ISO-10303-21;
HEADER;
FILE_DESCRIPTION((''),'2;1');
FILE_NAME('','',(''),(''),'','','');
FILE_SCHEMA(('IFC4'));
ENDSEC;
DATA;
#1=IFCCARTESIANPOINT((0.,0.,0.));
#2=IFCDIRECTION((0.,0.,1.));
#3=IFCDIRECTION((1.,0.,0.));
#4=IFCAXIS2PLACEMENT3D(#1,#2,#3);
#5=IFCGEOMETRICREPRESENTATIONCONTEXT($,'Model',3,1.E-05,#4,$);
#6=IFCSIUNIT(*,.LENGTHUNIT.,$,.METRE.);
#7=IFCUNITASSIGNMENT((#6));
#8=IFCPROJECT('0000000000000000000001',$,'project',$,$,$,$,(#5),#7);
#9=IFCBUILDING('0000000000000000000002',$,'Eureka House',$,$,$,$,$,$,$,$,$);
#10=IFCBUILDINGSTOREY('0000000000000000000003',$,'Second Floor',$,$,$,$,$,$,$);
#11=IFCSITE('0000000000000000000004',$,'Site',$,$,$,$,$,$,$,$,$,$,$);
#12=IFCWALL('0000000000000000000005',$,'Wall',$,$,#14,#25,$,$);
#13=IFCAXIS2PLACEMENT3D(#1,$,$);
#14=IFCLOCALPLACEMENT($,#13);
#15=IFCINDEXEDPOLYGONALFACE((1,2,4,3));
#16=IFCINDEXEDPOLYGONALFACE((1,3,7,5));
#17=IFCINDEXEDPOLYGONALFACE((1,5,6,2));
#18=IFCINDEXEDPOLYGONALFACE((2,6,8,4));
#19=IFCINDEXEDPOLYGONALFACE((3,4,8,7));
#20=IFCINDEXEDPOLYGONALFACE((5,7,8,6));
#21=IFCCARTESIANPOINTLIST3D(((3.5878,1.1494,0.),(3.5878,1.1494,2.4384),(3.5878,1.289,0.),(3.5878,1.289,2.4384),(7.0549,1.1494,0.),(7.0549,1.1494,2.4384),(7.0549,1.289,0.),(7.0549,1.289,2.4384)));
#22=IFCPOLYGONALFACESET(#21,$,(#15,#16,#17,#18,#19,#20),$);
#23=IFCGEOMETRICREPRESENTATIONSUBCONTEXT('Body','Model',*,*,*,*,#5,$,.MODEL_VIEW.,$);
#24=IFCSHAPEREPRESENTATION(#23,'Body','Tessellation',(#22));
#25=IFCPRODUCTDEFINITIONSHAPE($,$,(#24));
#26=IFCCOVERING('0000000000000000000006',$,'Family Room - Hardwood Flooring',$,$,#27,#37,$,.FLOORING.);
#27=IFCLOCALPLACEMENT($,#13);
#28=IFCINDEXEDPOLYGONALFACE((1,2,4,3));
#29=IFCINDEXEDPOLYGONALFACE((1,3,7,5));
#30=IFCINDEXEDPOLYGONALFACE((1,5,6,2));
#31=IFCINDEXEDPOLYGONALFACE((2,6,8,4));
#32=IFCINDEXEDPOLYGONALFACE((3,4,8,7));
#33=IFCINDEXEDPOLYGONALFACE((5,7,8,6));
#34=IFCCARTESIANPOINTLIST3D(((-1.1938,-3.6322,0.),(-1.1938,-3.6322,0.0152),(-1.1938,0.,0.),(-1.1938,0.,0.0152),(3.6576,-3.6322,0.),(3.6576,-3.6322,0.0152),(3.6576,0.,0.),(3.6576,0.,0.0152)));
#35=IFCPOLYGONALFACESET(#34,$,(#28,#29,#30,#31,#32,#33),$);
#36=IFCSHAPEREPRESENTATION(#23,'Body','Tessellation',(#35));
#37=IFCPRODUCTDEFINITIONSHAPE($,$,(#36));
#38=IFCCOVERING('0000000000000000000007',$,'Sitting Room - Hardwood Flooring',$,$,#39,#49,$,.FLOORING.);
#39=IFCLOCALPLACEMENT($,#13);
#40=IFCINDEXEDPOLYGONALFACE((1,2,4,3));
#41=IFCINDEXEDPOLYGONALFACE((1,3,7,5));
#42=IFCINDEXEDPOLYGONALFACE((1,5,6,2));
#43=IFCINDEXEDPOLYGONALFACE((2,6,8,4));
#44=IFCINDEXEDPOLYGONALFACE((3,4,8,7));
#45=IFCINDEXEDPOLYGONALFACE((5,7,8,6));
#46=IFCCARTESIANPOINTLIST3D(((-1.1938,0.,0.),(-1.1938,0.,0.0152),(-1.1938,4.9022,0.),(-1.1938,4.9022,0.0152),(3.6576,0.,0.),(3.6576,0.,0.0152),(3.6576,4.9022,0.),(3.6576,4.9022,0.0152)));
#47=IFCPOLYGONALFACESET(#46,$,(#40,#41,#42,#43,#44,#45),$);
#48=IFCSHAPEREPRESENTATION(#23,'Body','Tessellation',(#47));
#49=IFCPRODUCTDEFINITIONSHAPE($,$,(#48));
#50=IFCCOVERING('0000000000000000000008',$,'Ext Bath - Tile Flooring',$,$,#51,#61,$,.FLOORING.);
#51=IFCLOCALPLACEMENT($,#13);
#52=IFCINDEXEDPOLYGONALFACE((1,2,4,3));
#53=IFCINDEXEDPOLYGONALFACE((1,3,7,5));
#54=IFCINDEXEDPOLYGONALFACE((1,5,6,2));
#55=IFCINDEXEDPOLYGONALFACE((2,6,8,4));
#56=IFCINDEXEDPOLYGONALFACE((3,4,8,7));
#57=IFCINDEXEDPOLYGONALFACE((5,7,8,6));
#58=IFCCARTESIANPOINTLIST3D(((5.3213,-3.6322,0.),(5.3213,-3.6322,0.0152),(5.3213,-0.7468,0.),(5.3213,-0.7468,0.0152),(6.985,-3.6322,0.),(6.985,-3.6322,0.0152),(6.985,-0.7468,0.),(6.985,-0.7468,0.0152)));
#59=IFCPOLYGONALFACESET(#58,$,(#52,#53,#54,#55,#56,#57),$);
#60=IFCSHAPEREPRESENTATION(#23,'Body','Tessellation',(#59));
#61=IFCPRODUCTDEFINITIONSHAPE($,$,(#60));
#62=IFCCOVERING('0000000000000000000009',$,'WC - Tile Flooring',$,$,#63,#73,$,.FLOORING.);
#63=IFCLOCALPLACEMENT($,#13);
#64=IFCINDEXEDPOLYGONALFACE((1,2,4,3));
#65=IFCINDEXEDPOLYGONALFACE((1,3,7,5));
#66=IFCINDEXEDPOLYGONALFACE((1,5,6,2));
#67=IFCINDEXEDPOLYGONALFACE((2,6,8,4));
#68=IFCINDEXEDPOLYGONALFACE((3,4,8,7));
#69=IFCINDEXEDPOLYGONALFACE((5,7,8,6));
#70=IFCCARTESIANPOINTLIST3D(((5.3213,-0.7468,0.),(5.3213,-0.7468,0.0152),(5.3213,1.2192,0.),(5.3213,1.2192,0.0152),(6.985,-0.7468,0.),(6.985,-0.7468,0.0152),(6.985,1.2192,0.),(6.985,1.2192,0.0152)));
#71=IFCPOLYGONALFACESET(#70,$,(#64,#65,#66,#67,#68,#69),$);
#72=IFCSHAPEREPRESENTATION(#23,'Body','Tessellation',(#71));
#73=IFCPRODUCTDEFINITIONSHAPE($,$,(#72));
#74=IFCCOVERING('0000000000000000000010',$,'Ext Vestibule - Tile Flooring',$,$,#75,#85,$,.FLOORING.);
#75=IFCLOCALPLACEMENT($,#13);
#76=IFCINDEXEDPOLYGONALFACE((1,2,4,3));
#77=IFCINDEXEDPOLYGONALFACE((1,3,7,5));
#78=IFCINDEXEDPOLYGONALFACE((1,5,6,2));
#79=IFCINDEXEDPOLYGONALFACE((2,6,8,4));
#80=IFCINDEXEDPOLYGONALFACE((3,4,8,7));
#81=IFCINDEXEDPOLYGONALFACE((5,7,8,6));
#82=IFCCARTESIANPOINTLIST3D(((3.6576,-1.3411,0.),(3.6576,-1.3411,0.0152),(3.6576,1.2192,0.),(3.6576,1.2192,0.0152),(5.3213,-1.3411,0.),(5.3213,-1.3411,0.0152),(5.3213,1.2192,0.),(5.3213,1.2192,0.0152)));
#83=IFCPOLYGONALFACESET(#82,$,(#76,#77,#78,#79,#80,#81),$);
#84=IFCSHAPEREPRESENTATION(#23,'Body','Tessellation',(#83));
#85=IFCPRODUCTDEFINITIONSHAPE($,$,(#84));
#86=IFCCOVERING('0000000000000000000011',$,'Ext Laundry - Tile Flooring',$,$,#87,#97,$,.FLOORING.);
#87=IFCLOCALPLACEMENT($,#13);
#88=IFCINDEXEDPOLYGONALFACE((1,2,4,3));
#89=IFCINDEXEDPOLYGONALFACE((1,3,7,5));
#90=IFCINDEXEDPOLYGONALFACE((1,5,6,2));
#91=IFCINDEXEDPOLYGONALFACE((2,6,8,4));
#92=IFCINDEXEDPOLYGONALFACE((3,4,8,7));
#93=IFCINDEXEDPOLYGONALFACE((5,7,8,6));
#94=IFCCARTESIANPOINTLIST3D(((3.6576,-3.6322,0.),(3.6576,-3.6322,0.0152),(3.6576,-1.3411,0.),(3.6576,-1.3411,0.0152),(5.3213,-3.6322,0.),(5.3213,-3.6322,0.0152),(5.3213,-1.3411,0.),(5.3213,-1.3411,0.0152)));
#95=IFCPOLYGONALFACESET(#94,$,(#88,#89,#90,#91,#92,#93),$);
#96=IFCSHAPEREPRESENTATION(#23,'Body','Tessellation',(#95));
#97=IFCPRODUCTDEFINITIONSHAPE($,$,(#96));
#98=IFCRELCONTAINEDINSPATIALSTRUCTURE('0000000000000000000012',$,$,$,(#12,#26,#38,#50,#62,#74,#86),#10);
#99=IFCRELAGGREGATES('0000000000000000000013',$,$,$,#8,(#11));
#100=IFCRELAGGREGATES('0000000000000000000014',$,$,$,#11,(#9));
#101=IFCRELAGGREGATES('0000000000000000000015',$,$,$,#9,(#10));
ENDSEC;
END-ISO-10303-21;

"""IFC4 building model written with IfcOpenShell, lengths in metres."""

from ifc_helpers import new_model, si_unit, frame, origin, origin_with_axes, origin_2d, place, context, subcontext, project, spatial, rectangle, extrude, element, save


model = new_model("IFC4")

# Units and contexts
model_context = context("Model", 3, precision=1e-05, world=origin_with_axes())
body_context = subcontext(model_context, "Body", "Model", "MODEL_VIEW")
ifc_project = project(units=[si_unit("LENGTHUNIT", "METRE")], contexts=[model_context])

# Site, building, storey
site = spatial("IfcSite", under=ifc_project, Name="Site")
building = spatial("IfcBuilding", under=site, Name="Eureka House")
storey = spatial("IfcBuildingStorey", under=building, Name="Second Floor")

# Wall
wall_1_placement = place(None, frame((5.3213, 1.2192, 0.0), z_axis=(0.0, 0.0, 1.0), x_axis=(1.0, 0.0, 0.0)))
element("IfcWall", 1, at=wall_1_placement, inside=storey, Name="Wall", context=body_context, shape_type="SweptSolid", body=[
    extrude(rectangle(XDim=3.4671, YDim=0.1397, at=origin_2d()), origin(), (0.0, 0.0, 1.0), 2.4384),
])

# Coverings
covering_1_placement = place(None, frame((1.2319, -1.8161, 0.0), z_axis=(0.0, 0.0, 1.0), x_axis=(1.0, 0.0, 0.0)))
element("IfcCovering", 2, at=covering_1_placement, inside=storey, Name="Family Room - Hardwood Flooring", PredefinedType="FLOORING", context=body_context, shape_type="SweptSolid", body=[
    extrude(rectangle(XDim=4.8514, YDim=3.6322, at=origin_2d()), origin(), (0.0, 0.0, 1.0), 0.0152),
])
covering_2_placement = place(None, frame((1.2319, 2.4511, 0.0), z_axis=(0.0, 0.0, 1.0), x_axis=(1.0, 0.0, 0.0)))
element("IfcCovering", 3, at=covering_2_placement, inside=storey, Name="Sitting Room - Hardwood Flooring", PredefinedType="FLOORING", context=body_context, shape_type="SweptSolid", body=[
    extrude(rectangle(XDim=4.8514, YDim=4.9022, at=origin_2d()), origin(), (0.0, 0.0, 1.0), 0.0152),
])
covering_3_placement = place(None, frame((6.1532, -2.1895, 0.0), z_axis=(0.0, 0.0, 1.0), x_axis=(1.0, 0.0, 0.0)))
element("IfcCovering", 4, at=covering_3_placement, inside=storey, Name="Ext Bath - Tile Flooring", PredefinedType="FLOORING", context=body_context, shape_type="SweptSolid", body=[
    extrude(rectangle(XDim=1.6637, YDim=2.8855, at=origin_2d()), origin(), (0.0, 0.0, 1.0), 0.0152),
])
covering_4_placement = place(None, frame((6.1532, 0.2362, 0.0), z_axis=(0.0, 0.0, 1.0), x_axis=(1.0, 0.0, 0.0)))
element("IfcCovering", 5, at=covering_4_placement, inside=storey, Name="WC - Tile Flooring", PredefinedType="FLOORING", context=body_context, shape_type="SweptSolid", body=[
    extrude(rectangle(XDim=1.6637, YDim=1.966, at=origin_2d()), origin(), (0.0, 0.0, 1.0), 0.0152),
])
covering_5_placement = place(None, frame((4.4894, -0.061, 0.0), z_axis=(0.0, 0.0, 1.0), x_axis=(1.0, 0.0, 0.0)))
element("IfcCovering", 6, at=covering_5_placement, inside=storey, Name="Ext Vestibule - Tile Flooring", PredefinedType="FLOORING", context=body_context, shape_type="SweptSolid", body=[
    extrude(rectangle(XDim=1.6637, YDim=2.5603, at=origin_2d()), origin(), (0.0, 0.0, 1.0), 0.0152),
])
covering_6_placement = place(None, frame((4.4894, -2.4867, 0.0), z_axis=(0.0, 0.0, 1.0), x_axis=(1.0, 0.0, 0.0)))
element("IfcCovering", 7, at=covering_6_placement, inside=storey, Name="Ext Laundry - Tile Flooring", PredefinedType="FLOORING", context=body_context, shape_type="SweptSolid", body=[
    extrude(rectangle(XDim=1.6637, YDim=2.2911, at=origin_2d()), origin(), (0.0, 0.0, 1.0), 0.0152),
])

save(model, "model.ifc")
